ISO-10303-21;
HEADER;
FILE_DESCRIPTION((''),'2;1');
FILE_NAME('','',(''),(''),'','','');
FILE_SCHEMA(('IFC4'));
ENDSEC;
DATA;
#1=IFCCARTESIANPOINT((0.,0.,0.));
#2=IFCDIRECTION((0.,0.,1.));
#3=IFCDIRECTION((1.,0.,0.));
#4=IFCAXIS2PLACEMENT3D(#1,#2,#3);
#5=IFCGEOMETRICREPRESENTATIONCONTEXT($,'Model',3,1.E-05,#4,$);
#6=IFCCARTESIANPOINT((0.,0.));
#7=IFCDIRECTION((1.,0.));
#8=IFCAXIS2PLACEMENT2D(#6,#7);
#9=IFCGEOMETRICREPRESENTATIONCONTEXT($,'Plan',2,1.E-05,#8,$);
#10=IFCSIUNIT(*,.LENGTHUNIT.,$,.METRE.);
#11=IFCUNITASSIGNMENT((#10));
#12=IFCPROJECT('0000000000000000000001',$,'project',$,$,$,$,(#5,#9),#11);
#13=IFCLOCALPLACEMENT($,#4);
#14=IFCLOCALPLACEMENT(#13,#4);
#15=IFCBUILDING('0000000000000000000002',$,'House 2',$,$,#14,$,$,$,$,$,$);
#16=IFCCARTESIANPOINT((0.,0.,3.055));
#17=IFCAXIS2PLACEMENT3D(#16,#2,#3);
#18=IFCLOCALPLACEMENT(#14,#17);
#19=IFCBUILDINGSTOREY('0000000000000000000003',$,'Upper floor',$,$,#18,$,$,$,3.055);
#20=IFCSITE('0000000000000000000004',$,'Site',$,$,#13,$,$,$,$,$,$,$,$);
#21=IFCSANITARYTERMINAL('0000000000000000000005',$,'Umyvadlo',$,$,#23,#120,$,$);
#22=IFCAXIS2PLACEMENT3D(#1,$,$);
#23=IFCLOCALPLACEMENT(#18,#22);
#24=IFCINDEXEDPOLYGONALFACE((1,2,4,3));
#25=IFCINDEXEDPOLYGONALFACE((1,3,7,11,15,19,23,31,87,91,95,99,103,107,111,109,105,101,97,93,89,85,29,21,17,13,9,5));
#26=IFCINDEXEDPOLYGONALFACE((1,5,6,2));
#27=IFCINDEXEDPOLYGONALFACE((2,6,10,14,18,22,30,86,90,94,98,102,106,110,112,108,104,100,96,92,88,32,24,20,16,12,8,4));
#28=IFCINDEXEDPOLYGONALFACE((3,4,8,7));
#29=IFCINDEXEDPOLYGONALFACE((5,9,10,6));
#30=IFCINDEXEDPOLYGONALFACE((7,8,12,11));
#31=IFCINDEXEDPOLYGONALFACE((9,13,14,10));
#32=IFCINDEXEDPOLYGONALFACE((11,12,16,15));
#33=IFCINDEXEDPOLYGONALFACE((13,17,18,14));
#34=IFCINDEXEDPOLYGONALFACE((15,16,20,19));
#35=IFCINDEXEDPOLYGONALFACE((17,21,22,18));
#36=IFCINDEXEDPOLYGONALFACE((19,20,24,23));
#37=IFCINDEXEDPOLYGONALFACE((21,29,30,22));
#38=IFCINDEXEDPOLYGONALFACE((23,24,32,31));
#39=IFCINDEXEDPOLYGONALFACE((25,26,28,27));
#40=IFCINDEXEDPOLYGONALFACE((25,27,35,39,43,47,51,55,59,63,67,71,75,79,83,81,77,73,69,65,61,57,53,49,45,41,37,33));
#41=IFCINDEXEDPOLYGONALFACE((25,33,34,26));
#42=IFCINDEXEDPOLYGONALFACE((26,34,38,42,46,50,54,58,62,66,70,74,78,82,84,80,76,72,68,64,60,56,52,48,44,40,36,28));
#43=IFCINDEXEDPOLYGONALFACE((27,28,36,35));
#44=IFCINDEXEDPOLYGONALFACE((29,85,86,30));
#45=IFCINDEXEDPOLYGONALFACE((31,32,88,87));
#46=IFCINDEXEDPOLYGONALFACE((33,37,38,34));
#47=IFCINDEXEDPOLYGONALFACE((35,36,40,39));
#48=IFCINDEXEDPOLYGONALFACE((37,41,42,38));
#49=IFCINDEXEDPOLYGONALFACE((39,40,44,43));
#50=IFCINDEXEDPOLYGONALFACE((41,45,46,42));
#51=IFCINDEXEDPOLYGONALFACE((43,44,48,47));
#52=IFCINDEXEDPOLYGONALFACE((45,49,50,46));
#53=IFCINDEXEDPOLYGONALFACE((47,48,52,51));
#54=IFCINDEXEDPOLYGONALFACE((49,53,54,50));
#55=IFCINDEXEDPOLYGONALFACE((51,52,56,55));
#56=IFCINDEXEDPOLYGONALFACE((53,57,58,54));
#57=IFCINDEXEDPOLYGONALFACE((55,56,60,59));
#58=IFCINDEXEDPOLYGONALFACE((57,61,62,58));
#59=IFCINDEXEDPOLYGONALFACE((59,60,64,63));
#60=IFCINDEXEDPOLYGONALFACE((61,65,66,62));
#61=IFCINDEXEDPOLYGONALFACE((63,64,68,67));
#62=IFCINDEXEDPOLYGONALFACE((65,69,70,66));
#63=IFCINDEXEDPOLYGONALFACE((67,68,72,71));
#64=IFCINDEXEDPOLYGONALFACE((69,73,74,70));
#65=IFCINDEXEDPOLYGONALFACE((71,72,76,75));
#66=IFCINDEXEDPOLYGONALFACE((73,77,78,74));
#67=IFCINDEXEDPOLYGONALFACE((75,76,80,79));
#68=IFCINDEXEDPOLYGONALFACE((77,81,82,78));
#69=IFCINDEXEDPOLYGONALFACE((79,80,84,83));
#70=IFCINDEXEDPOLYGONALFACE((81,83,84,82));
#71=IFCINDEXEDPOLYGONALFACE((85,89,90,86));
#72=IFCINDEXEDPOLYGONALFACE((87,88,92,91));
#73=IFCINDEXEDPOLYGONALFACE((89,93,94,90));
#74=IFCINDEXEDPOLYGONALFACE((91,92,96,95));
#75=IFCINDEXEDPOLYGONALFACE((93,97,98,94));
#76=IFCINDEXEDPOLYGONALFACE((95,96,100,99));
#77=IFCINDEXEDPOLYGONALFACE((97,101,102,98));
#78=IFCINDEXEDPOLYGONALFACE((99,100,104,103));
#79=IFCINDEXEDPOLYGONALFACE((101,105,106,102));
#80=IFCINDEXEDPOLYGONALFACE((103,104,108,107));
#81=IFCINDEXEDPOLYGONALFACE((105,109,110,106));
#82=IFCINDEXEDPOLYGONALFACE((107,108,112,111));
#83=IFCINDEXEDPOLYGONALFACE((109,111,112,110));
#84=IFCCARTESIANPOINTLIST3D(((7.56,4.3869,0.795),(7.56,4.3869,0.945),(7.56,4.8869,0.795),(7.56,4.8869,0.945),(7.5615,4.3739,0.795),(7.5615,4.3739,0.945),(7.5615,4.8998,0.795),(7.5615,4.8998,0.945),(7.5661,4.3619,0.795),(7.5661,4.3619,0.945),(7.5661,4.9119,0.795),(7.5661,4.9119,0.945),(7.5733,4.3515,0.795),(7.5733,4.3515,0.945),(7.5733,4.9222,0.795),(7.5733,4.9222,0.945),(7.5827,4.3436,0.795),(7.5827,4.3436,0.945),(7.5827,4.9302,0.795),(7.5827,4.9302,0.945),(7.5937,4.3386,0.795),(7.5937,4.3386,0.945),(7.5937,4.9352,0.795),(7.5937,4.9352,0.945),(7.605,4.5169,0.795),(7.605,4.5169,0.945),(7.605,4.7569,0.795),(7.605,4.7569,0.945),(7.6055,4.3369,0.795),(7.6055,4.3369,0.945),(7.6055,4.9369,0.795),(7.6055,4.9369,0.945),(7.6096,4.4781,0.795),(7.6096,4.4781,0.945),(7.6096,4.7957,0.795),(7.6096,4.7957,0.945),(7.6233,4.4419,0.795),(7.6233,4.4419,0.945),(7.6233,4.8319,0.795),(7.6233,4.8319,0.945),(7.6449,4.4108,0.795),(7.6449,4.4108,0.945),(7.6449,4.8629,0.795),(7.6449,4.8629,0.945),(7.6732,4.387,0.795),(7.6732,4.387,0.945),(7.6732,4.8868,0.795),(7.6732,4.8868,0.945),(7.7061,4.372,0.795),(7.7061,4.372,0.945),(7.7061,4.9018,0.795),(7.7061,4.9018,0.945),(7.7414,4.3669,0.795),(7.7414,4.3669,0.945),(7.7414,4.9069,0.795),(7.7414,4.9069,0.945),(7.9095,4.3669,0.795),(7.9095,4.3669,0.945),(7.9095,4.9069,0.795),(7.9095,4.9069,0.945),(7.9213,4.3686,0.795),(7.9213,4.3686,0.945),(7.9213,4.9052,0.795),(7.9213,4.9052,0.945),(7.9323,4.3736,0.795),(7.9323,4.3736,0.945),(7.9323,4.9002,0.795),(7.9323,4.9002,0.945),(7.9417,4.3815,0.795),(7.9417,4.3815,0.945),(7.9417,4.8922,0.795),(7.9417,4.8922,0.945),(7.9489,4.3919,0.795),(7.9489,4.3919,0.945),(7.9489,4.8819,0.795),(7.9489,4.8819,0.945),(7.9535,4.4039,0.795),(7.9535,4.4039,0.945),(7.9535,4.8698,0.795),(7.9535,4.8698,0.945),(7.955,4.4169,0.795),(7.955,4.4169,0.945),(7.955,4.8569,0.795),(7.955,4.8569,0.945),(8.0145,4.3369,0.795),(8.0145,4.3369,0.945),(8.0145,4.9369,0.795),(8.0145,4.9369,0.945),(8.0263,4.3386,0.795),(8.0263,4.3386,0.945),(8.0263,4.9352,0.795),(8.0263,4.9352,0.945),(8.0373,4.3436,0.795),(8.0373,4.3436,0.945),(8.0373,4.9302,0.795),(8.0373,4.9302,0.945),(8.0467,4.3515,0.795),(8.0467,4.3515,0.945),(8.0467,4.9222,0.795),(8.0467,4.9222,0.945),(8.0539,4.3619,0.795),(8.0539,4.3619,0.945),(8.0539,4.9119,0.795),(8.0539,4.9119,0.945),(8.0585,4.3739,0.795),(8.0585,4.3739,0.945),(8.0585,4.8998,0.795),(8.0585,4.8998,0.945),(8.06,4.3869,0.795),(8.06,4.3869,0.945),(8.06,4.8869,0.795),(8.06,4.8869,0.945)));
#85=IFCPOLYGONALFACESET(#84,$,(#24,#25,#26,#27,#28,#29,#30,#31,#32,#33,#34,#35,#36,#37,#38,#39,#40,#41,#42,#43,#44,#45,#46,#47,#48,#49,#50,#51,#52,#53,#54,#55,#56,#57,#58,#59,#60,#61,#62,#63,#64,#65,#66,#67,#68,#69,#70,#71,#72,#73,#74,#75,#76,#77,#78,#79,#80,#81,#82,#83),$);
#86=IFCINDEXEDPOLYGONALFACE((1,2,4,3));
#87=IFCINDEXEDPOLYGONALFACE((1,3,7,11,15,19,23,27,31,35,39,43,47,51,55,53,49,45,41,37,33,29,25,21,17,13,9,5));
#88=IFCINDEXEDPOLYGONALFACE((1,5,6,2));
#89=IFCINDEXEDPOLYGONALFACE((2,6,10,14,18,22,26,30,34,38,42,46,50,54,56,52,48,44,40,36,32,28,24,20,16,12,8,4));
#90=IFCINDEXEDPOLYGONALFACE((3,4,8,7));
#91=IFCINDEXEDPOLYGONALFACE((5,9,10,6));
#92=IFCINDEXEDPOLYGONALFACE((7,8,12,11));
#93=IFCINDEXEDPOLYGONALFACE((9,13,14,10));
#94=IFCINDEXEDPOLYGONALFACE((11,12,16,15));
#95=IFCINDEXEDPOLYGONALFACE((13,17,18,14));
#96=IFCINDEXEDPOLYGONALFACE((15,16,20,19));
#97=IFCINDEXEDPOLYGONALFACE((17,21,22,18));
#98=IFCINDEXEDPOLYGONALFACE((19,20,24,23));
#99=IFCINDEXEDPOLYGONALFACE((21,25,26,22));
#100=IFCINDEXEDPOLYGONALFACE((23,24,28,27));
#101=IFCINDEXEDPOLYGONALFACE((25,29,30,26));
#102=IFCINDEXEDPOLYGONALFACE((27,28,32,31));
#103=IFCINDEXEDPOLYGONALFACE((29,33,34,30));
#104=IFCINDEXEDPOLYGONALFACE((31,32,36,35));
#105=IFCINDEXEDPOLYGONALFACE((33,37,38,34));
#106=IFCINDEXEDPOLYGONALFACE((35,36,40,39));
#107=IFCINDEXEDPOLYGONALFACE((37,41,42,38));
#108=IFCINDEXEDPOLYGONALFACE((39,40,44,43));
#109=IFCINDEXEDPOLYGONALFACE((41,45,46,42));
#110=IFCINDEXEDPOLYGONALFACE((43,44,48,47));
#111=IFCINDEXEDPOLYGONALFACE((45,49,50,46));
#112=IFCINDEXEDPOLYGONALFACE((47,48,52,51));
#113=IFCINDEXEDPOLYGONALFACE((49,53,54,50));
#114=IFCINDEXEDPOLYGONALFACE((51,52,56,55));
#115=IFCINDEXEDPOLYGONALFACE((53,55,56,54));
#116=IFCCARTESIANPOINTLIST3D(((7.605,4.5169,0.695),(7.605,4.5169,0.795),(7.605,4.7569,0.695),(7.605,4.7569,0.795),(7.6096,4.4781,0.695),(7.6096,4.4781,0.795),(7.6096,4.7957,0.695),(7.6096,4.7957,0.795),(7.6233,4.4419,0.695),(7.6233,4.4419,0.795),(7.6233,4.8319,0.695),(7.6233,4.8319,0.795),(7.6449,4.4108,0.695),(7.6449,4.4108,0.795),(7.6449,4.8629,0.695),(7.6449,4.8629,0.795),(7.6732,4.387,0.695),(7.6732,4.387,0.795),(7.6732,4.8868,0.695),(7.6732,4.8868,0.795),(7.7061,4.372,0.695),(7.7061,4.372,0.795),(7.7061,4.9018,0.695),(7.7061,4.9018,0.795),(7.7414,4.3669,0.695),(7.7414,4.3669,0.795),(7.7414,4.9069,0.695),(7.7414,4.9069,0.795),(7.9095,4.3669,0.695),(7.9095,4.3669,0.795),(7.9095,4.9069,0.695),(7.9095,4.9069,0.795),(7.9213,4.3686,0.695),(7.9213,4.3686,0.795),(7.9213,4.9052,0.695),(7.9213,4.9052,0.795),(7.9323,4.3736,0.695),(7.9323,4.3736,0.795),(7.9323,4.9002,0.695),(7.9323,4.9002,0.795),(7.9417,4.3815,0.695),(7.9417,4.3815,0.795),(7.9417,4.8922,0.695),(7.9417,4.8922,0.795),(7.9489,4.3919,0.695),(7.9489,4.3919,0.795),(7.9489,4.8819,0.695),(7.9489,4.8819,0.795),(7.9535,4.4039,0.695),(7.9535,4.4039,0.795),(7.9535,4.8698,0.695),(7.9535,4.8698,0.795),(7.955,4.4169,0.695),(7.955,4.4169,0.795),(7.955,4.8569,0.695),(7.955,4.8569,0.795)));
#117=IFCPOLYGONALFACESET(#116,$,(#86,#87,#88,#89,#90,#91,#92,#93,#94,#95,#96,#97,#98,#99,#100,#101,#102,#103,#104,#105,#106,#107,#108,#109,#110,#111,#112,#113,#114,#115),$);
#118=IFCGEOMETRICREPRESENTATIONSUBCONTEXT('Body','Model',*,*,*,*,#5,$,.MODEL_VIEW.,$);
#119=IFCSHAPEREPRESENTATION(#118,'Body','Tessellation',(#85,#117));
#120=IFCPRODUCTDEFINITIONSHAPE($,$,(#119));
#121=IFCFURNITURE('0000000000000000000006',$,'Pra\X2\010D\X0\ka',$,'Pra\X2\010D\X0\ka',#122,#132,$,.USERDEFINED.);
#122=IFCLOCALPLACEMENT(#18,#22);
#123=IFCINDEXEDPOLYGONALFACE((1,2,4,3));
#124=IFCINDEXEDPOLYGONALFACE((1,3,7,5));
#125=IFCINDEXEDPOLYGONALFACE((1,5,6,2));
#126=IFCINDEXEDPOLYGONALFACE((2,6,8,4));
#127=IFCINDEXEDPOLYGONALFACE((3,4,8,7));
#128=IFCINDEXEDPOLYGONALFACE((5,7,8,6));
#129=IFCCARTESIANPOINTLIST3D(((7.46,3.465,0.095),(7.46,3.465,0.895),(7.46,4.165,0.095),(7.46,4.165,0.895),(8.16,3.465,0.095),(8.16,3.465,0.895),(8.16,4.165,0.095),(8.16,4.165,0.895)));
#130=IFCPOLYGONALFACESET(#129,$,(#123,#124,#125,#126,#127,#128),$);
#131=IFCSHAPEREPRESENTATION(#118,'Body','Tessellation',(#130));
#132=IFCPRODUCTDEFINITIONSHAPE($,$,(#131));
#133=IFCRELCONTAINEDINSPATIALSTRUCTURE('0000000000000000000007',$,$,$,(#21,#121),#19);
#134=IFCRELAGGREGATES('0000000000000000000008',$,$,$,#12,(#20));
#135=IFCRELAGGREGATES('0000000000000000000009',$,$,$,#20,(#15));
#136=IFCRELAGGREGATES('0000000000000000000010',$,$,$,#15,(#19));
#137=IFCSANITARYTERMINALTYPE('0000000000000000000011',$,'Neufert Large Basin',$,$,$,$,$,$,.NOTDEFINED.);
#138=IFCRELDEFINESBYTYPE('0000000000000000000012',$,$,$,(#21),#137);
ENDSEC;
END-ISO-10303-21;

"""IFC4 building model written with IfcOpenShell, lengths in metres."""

from ifc_helpers import new_model, entity, si_unit, frame, origin_with_axes, origin_2d_with_axis, place, context, subcontext, project, spatial, indexed_curve, outline, extrude, shape, source, transform, mapped, type_object, type_shapes, element, save


model = new_model("IFC4")

# Units and contexts
model_context = context("Model", 3, precision=1e-05, world=origin_with_axes())
plan_context = context("Plan", 2, precision=1e-05, world=origin_2d_with_axis())
body_context_1 = subcontext(model_context, "Body", "Model", "MODEL_VIEW")
body_context_2 = subcontext(plan_context, "Body", "Plan", "PLAN_VIEW")
ifc_project = project(units=[si_unit("LENGTHUNIT", "METRE")], contexts=[model_context, plan_context])

# Site, building, storey
site_placement = place(None, origin_with_axes())
site = spatial("IfcSite", under=ifc_project, at=site_placement, Name="Site")
building_placement = place(site_placement, origin_with_axes())
building = spatial("IfcBuilding", under=site, at=building_placement, Name="House 2")
storey_placement = place(building_placement, frame((0.0, 0.0, 3.055), z_axis=(0.0, 0.0, 1.0), x_axis=(1.0, 0.0, 0.0)))
storey = spatial("IfcBuildingStorey", under=building, at=storey_placement, Name="Upper floor", Elevation=3.055)

# Sanitary terminal
sanitary_terminal_type_1 = type_object("IfcSanitaryTerminalType", Name="Neufert Large Basin", PredefinedType="NOTDEFINED")
shared_indexed_poly_curve = entity("IfcIndexedPolyCurve", entity("IfcCartesianPointList2D", [[0.03, 0.1995], [0.0739, 0.0934], [0.18, 0.0495], [0.42, 0.0495], [0.5261, 0.0934], [0.57, 0.1995], [0.57, 0.3845], [0.5554, 0.4199], [0.52, 0.4345], [0.08, 0.4345], [0.0446, 0.4199], [0.03, 0.3845]]), [entity("IfcLineIndex", [12, 1]), entity("IfcArcIndex", [1, 2, 3]), entity("IfcLineIndex", [3, 4]), entity("IfcArcIndex", [4, 5, 6]), entity("IfcLineIndex", [6, 7]), entity("IfcArcIndex", [7, 8, 9]), entity("IfcLineIndex", [9, 10]), entity("IfcArcIndex", [10, 11, 12])])
shared_shape_1 = source(origin_with_axes(), body_context_1, "Body", "SweptSolid", [
    entity("IfcExtrudedAreaSolid", entity("IfcArbitraryProfileDefWithVoids", "AREA", None, entity("IfcIndexedPolyCurve", entity("IfcCartesianPointList2D", [[0.0, 0.05], [0.0146, 0.0146], [0.05, 0.0], [0.55, 0.0], [0.5854, 0.0146], [0.6, 0.05], [0.6, 0.5], [0.5854, 0.5354], [0.55, 0.55], [0.05, 0.55], [0.0146, 0.5354], [0.0, 0.5]]), [entity("IfcLineIndex", [12, 1]), entity("IfcArcIndex", [1, 2, 3]), entity("IfcLineIndex", [3, 4]), entity("IfcArcIndex", [4, 5, 6]), entity("IfcLineIndex", [6, 7]), entity("IfcArcIndex", [7, 8, 9]), entity("IfcLineIndex", [9, 10]), entity("IfcArcIndex", [10, 11, 12])]), [shared_indexed_poly_curve]), entity("IfcAxis2Placement3D", entity("IfcCartesianPoint", [-0.3, -0.55, 0.1]), entity("IfcDirection", [0.0, 0.0, 1.0]), entity("IfcDirection", [1.0, 0.0, 0.0])), entity("IfcDirection", [0.0, 0.0, 1.0]), 0.15),
    entity("IfcExtrudedAreaSolid", entity("IfcArbitraryClosedProfileDef", "AREA", None, shared_indexed_poly_curve), entity("IfcAxis2Placement3D", entity("IfcCartesianPoint", [-0.3, -0.55, 0.0]), entity("IfcDirection", [0.0, 0.0, 1.0]), entity("IfcDirection", [1.0, 0.0, 0.0])), entity("IfcDirection", [0.0, 0.0, 1.0]), 0.1),
])
shared_shape_2 = source(origin_with_axes(), body_context_2, "Body", "Curve2D", [
    entity("IfcIndexedPolyCurve", entity("IfcCartesianPointList2D", [[-0.3, -0.5], [-0.2854, -0.5354], [-0.25, -0.55], [0.25, -0.55], [0.2854, -0.5354], [0.3, -0.5], [0.3, -0.05], [0.2854, -0.0146], [0.25, 0.0], [-0.25, 0.0], [-0.2854, -0.0146], [-0.3, -0.05]]), [entity("IfcLineIndex", [12, 1]), entity("IfcArcIndex", [1, 2, 3]), entity("IfcLineIndex", [3, 4]), entity("IfcArcIndex", [4, 5, 6]), entity("IfcLineIndex", [6, 7]), entity("IfcArcIndex", [7, 8, 9]), entity("IfcLineIndex", [9, 10]), entity("IfcArcIndex", [10, 11, 12]), entity("IfcLineIndex", [12, 1])]),
    entity("IfcIndexedPolyCurve", entity("IfcCartesianPointList2D", [[-0.27, -0.3505], [-0.2261, -0.4566], [-0.12, -0.5005], [0.12, -0.5005], [0.2261, -0.4566], [0.27, -0.3505], [0.27, -0.1655], [0.2554, -0.1301], [0.22, -0.1155], [-0.22, -0.1155], [-0.2554, -0.1301], [-0.27, -0.1655]]), [entity("IfcLineIndex", [12, 1]), entity("IfcArcIndex", [1, 2, 3]), entity("IfcLineIndex", [3, 4]), entity("IfcArcIndex", [4, 5, 6]), entity("IfcLineIndex", [6, 7]), entity("IfcArcIndex", [7, 8, 9]), entity("IfcLineIndex", [9, 10]), entity("IfcArcIndex", [10, 11, 12]), entity("IfcLineIndex", [12, 1])]),
    entity("IfcIndexedPolyCurve", entity("IfcCartesianPointList2D", [[0.0, -0.0413], [0.0, -0.1613]])),
])
type_shapes(sanitary_terminal_type_1, [shared_shape_1, shared_shape_2])
sanitary_terminal_1_placement = place(storey_placement, frame((8.06, 4.6369, 0.695), z_axis=(0.0, 0.0, 1.0), x_axis=(0.0, -1.0, 0.0)))
element("IfcSanitaryTerminal", 1, at=sanitary_terminal_1_placement, inside=storey, type_object=sanitary_terminal_type_1, Name="Umyvadlo", shapes=[
    shape(body_context_1, "Body", "MappedRepresentation", [mapped(shared_shape_1, transform((0.0, 0.0, 0.0), x_axis=(1.0, 0.0, 0.0), y_axis=(0.0, 1.0, 0.0), z_axis=(0.0, 0.0, 1.0), scale=1.0, scale2=0.909091, scale3=1.0, uniform=False))]),
    shape(body_context_2, "Body", "MappedRepresentation", [mapped(shared_shape_2, transform((0.0, 0.0, 0.0), x_axis=(1.0, 0.0, 0.0), y_axis=(0.0, 1.0, 0.0), z_axis=(0.0, 0.0, 1.0), scale=1.0, scale2=0.909091, scale3=1.0, uniform=False))]),
])

# Furniture
furniture_placement = place(storey_placement, frame((7.81, 3.815, 0.095), z_axis=(0.0, 0.0, 1.0), x_axis=(1.0, 0.0, 0.0)))
element("IfcFurniture", 2, at=furniture_placement, inside=storey, Name="Pračka", ObjectType="Pračka", PredefinedType="USERDEFINED", shapes=[
    shape(body_context_1, "Body", "SweptSolid", [extrude(outline(indexed_curve([(-0.35, -0.35), (0.35, -0.35), (0.35, 0.35), (-0.35, 0.35)])), None, (0.0, 0.0, 1.0), 0.8)]),
    shape(body_context_2, "Body", "Curve2D", [entity("IfcIndexedPolyCurve", entity("IfcCartesianPointList2D", [[-0.35, -0.35], [0.35, -0.35], [0.35, 0.35], [-0.35, 0.35], [-0.35, -0.35]]), None, False)]),
])

save(model, "model.ifc")
